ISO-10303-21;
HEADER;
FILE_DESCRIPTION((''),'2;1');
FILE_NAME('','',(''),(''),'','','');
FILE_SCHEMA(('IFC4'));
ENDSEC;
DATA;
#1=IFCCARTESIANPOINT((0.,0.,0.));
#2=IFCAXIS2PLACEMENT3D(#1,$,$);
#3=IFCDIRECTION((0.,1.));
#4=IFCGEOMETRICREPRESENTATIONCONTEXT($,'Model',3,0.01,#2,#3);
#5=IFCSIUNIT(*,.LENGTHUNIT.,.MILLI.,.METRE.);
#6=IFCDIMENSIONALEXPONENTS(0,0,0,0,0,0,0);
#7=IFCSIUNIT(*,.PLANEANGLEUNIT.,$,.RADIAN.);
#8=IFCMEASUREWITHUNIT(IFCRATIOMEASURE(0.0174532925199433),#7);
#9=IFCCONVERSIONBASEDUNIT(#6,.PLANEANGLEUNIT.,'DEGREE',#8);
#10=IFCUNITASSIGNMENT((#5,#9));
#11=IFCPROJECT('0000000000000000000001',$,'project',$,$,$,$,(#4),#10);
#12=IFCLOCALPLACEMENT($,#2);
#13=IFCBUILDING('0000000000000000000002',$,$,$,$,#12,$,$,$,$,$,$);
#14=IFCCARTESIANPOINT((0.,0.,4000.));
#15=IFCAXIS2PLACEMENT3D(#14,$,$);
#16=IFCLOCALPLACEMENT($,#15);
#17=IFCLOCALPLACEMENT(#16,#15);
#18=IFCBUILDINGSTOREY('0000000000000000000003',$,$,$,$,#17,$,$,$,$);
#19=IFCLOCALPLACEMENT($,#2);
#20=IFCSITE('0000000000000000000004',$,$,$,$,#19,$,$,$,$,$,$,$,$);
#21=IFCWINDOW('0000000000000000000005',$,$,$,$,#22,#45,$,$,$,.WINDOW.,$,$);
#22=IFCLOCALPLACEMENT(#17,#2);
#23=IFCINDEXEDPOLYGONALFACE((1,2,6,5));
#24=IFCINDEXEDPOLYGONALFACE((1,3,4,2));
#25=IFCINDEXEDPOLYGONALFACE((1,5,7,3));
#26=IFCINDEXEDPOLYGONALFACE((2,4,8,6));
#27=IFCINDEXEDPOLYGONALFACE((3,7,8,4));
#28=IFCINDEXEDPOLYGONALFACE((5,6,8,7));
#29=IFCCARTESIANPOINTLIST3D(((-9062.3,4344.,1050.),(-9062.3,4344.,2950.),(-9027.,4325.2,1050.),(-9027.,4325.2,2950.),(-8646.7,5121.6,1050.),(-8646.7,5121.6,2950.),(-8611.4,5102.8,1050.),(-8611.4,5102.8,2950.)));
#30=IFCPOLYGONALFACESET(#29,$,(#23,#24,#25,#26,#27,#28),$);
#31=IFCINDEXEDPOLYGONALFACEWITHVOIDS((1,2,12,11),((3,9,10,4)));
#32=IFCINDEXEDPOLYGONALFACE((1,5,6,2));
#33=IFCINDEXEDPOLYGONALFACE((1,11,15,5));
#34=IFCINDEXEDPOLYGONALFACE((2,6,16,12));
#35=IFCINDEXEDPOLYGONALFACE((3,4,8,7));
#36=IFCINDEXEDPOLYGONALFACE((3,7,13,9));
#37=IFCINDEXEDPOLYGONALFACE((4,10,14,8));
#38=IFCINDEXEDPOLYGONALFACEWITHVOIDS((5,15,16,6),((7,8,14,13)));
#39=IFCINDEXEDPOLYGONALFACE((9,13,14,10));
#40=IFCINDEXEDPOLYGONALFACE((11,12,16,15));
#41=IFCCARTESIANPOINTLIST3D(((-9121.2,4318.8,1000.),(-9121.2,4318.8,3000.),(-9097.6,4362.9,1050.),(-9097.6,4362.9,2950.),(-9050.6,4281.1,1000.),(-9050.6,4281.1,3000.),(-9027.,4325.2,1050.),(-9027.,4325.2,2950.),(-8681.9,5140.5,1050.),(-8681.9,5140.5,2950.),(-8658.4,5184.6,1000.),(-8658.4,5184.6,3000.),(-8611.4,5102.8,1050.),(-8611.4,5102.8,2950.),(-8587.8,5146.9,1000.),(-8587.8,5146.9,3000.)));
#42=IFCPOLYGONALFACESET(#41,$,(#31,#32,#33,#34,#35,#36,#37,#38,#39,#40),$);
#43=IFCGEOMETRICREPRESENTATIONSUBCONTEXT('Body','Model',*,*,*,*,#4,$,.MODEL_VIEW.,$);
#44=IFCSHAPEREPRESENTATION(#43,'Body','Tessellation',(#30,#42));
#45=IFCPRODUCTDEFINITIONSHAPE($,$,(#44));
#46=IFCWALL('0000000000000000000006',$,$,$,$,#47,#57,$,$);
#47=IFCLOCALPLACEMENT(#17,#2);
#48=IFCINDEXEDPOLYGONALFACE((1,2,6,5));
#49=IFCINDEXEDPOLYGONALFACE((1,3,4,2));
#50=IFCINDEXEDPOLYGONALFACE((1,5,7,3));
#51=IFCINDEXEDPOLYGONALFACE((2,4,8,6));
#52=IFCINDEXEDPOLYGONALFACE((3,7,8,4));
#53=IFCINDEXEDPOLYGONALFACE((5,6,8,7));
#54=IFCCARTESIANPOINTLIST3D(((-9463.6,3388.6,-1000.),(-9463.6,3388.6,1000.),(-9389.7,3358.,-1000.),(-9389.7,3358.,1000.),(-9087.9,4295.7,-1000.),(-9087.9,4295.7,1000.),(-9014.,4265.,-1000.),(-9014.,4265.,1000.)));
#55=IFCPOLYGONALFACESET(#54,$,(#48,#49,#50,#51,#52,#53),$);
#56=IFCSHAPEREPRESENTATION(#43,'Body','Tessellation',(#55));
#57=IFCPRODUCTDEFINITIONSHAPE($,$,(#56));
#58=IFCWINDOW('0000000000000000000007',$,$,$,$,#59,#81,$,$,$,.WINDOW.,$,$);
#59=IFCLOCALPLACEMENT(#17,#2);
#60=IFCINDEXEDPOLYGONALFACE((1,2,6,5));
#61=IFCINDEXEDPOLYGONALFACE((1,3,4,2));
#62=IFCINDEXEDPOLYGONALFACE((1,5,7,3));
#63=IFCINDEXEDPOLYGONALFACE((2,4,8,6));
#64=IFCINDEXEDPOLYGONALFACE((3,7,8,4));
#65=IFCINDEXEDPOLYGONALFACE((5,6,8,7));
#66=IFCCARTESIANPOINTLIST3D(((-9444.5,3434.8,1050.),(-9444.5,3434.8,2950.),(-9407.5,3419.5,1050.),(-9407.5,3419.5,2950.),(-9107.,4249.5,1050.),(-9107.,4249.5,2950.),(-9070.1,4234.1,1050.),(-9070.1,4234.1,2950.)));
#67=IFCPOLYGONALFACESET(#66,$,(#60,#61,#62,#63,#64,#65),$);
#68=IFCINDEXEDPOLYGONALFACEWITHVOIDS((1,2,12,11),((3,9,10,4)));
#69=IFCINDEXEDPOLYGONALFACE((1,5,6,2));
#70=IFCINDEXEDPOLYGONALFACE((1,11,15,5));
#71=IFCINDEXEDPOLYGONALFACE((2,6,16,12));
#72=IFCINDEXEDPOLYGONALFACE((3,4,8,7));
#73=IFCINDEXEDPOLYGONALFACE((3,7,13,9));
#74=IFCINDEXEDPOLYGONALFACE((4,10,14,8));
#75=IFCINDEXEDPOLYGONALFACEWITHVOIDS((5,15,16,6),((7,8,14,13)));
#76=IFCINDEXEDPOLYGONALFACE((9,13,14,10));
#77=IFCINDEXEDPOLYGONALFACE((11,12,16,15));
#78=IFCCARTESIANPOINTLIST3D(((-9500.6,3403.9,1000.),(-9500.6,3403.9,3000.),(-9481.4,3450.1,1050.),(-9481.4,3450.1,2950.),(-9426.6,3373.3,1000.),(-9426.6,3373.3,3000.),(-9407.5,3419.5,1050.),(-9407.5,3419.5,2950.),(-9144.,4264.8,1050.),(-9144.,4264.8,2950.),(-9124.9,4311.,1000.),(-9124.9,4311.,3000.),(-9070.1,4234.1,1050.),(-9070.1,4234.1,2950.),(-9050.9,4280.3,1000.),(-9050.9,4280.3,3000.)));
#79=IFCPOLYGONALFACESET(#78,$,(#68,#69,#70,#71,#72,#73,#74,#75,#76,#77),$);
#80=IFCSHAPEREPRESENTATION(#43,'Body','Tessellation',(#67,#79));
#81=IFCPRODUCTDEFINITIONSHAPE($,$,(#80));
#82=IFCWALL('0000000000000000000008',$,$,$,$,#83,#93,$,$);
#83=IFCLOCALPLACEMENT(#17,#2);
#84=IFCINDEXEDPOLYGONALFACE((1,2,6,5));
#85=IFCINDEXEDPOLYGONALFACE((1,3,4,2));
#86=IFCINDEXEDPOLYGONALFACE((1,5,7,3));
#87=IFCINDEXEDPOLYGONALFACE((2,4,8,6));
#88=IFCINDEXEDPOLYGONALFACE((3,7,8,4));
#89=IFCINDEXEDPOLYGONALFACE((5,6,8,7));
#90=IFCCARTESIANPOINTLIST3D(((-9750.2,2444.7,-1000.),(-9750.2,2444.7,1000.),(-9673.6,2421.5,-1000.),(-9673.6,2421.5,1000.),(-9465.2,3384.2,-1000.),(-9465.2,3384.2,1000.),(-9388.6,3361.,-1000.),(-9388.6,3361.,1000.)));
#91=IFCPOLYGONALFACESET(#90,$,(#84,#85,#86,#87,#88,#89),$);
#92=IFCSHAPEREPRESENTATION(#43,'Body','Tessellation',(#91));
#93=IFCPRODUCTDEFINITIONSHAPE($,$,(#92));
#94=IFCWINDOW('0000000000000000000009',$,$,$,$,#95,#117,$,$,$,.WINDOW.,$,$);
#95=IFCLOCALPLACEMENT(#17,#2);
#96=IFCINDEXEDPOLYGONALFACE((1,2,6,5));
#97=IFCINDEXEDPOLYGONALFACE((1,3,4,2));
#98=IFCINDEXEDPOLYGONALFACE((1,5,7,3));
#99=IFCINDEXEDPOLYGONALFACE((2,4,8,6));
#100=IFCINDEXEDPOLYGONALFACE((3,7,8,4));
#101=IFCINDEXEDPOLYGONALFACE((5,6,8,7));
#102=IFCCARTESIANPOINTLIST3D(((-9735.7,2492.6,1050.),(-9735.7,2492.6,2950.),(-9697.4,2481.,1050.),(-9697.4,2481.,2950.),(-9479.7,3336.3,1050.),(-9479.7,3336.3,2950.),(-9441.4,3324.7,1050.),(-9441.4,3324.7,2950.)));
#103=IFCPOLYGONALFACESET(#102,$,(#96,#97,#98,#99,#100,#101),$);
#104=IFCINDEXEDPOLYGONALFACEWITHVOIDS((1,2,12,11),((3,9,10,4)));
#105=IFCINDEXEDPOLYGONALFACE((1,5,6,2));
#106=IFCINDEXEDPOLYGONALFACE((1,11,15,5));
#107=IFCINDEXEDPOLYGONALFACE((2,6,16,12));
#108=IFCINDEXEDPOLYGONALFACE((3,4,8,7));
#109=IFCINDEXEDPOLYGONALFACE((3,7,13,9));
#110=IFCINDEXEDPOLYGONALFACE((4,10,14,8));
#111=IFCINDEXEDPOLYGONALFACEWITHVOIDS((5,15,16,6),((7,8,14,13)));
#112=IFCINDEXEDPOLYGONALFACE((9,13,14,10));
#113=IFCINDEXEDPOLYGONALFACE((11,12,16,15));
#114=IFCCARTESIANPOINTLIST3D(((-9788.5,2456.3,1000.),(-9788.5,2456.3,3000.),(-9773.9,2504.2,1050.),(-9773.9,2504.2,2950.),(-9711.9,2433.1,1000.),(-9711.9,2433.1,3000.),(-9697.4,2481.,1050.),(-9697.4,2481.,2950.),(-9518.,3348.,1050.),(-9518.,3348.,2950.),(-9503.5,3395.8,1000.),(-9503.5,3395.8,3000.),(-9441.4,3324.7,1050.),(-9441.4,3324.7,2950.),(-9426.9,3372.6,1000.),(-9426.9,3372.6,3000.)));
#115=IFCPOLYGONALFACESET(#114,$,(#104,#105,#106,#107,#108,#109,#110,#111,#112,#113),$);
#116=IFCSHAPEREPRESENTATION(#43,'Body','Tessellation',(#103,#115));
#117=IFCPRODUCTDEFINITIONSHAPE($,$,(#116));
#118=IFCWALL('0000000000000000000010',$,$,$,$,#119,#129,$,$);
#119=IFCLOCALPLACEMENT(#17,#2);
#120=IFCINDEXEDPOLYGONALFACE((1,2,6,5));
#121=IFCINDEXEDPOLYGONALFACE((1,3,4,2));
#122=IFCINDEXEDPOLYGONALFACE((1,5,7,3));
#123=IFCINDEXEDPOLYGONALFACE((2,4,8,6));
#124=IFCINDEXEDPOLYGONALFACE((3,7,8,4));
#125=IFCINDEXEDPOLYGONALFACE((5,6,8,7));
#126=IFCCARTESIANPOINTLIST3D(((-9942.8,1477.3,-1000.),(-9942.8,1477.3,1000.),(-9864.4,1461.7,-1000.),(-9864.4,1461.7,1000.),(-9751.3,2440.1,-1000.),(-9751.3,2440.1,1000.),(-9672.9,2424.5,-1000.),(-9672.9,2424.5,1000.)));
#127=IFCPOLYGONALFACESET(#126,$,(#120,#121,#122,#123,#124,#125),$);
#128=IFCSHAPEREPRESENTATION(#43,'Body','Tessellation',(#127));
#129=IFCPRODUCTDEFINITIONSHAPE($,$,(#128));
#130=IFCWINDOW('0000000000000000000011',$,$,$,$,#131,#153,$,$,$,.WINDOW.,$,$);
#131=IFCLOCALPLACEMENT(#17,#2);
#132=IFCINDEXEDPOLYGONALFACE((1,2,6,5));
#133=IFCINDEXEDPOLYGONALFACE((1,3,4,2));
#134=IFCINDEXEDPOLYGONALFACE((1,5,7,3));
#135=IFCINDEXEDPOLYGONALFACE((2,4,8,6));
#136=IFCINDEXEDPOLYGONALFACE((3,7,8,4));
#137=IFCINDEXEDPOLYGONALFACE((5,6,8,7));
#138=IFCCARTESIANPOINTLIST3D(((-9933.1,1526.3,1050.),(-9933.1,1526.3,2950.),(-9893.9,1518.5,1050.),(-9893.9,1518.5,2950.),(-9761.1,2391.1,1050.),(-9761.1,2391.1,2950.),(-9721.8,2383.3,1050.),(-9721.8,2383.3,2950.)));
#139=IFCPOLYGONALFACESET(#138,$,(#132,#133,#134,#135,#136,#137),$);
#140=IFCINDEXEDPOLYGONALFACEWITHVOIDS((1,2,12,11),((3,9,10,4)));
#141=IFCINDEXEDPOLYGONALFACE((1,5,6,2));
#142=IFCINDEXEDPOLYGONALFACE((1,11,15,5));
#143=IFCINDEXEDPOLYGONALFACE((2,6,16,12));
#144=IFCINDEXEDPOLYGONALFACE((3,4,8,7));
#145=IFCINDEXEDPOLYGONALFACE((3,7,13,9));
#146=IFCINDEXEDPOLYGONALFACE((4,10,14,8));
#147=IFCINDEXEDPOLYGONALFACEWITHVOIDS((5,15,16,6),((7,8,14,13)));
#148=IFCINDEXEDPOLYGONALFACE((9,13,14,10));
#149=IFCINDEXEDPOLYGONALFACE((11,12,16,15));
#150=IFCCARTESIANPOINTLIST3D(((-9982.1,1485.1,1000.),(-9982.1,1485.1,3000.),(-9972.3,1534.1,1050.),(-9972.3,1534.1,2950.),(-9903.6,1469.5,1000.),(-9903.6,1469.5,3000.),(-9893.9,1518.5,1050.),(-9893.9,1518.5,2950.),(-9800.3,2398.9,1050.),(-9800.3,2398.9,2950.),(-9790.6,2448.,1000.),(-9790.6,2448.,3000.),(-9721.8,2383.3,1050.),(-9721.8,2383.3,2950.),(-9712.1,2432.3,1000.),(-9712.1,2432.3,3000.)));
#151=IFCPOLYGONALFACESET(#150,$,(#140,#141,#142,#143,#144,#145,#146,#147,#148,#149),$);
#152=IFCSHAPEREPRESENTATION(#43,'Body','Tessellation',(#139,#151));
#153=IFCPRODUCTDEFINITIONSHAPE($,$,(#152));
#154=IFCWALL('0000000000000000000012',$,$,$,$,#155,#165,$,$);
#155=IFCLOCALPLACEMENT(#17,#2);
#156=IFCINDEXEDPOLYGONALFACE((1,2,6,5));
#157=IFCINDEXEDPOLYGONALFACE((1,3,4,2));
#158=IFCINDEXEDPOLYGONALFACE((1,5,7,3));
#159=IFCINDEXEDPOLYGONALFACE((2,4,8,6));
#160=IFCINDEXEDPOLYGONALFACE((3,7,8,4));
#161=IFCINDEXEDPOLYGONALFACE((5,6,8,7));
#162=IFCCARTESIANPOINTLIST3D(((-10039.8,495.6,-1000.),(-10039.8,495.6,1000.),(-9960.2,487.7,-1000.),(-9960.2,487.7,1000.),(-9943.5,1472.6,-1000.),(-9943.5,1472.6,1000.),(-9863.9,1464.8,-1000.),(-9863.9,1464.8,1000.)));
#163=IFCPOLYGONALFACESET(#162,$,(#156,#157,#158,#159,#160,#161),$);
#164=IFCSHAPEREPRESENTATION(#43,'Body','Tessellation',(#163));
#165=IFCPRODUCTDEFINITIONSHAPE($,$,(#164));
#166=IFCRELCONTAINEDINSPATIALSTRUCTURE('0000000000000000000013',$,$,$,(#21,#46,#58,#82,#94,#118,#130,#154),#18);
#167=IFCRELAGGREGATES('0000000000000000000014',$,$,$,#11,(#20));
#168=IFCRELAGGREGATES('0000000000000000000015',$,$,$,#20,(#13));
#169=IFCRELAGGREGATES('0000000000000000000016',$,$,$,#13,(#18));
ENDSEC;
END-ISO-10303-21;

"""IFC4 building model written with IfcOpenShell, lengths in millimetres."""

from ifc_helpers import new_model, entity, si_unit, converted_unit, direction, frame, origin, origin_2d, place, context, subcontext, project, spatial, rectangle, extrude, element, save


model = new_model("IFC4")

# Units and contexts
model_context = context("Model", 3, precision=0.01, world=origin(), true_north=direction((0.0, 1.0)))
body_context = subcontext(model_context, "Body", "Model", "MODEL_VIEW")
ifc_project = project(units=[si_unit("LENGTHUNIT", "METRE", prefix="MILLI"), converted_unit("PLANEANGLEUNIT", "DEGREE", entity("IfcRatioMeasure", 0.0174532925199433), si_unit("PLANEANGLEUNIT", "RADIAN"), dimensions=[0, 0, 0, 0, 0, 0, 0])], contexts=[model_context])

# Site, building, storey
site_placement = place(None, origin())
site = spatial("IfcSite", under=ifc_project, at=site_placement)
building_placement = place(None, origin())
building = spatial("IfcBuilding", under=site, at=building_placement)
placement = place(None, frame((0.0, 0.0, 4000.0)))
storey_placement = place(placement, frame((0.0, 0.0, 4000.0)))
storey = spatial("IfcBuildingStorey", under=building, at=storey_placement)

# Shared definitions
cartesian_point_1 = entity("IfcCartesianPoint", [-440.9, -950.0])
shared_polyline = entity("IfcPolyline", [cartesian_point_1, entity("IfcCartesianPoint", [-440.9, 950.0]), entity("IfcCartesianPoint", [-440.9, 950.0]), entity("IfcCartesianPoint", [440.9, 950.0]), entity("IfcCartesianPoint", [440.9, 950.0]), entity("IfcCartesianPoint", [440.9, -950.0]), entity("IfcCartesianPoint", [440.9, -950.0]), entity("IfcCartesianPoint", [-440.9, -950.0]), cartesian_point_1])

# Window
window_1_placement = place(storey_placement, frame((-8819.2, 4714.0, 2000.0), z_axis=(0.0, 0.0, 1.0), x_axis=(-4713.96836, -8819.212113, 0.0)))
cartesian_point_2 = entity("IfcCartesianPoint", [-490.9, -1000.0])
element("IfcWindow", 1, at=window_1_placement, inside=storey, PredefinedType="WINDOW", context=body_context, shape_type="SweptSolid", body=[
    entity("IfcExtrudedAreaSolid", entity("IfcArbitraryClosedProfileDef", "AREA", None, shared_polyline), entity("IfcAxis2Placement3D", entity("IfcCartesianPoint", [0.0, 0.0, 0.0]), entity("IfcDirection", [0.0, -1.0, 0.0]), entity("IfcDirection", [1.0, 0.0, 0.0])), entity("IfcDirection", [0.0, 0.0, 1.0]), 40.0),
    entity("IfcExtrudedAreaSolid", entity("IfcArbitraryProfileDefWithVoids", "AREA", None, entity("IfcPolyline", [cartesian_point_2, entity("IfcCartesianPoint", [-490.9, 1000.0]), entity("IfcCartesianPoint", [-490.9, 1000.0]), entity("IfcCartesianPoint", [490.9, 1000.0]), entity("IfcCartesianPoint", [490.9, 1000.0]), entity("IfcCartesianPoint", [490.9, -1000.0]), entity("IfcCartesianPoint", [490.9, -1000.0]), entity("IfcCartesianPoint", [-490.9, -1000.0]), cartesian_point_2]), [shared_polyline]), entity("IfcAxis2Placement3D", entity("IfcCartesianPoint", [0.0, 0.0, 0.0]), entity("IfcDirection", [0.0, -1.0, 0.0]), entity("IfcDirection", [1.0, 0.0, 0.0])), entity("IfcDirection", [0.0, 0.0, 1.0]), 80.0),
])

# Wall
wall_1_placement = place(storey_placement, frame((-9238.8, 3826.8, -1000.0), z_axis=(0.0, 0.0, 1.0), x_axis=(-3826.834994, -9238.795048, 0.0)))
element("IfcWall", 2, at=wall_1_placement, inside=storey, context=body_context, shape_type="SweptSolid", body=[
    extrude(rectangle(XDim=981.7, YDim=80.0, at=origin_2d()), origin(), (0.0, 0.0, 1.0), 2000.0),
])

# Window
window_2_placement = place(storey_placement, frame((-9238.8, 3826.8, 2000.0), z_axis=(0.0, 0.0, 1.0), x_axis=(-3826.834994, -9238.795048, 0.0)))
cartesian_point_3 = entity("IfcCartesianPoint", [-490.9, -1000.0])
element("IfcWindow", 3, at=window_2_placement, inside=storey, PredefinedType="WINDOW", context=body_context, shape_type="SweptSolid", body=[
    entity("IfcExtrudedAreaSolid", entity("IfcArbitraryClosedProfileDef", "AREA", None, shared_polyline), entity("IfcAxis2Placement3D", entity("IfcCartesianPoint", [0.0, 0.0, 0.0]), entity("IfcDirection", [0.0, -1.0, 0.0]), entity("IfcDirection", [1.0, 0.0, 0.0])), entity("IfcDirection", [0.0, 0.0, 1.0]), 40.0),
    entity("IfcExtrudedAreaSolid", entity("IfcArbitraryProfileDefWithVoids", "AREA", None, entity("IfcPolyline", [cartesian_point_3, entity("IfcCartesianPoint", [-490.9, 1000.0]), entity("IfcCartesianPoint", [-490.9, 1000.0]), entity("IfcCartesianPoint", [490.9, 1000.0]), entity("IfcCartesianPoint", [490.9, 1000.0]), entity("IfcCartesianPoint", [490.9, -1000.0]), entity("IfcCartesianPoint", [490.9, -1000.0]), entity("IfcCartesianPoint", [-490.9, -1000.0]), cartesian_point_3]), [shared_polyline]), entity("IfcAxis2Placement3D", entity("IfcCartesianPoint", [0.0, 0.0, 0.0]), entity("IfcDirection", [0.0, -1.0, 0.0]), entity("IfcDirection", [1.0, 0.0, 0.0])), entity("IfcDirection", [0.0, 0.0, 1.0]), 80.0),
])

# Wall
wall_2_placement = place(storey_placement, frame((-9569.4, 2902.8, -1000.0), z_axis=(0.0, 0.0, 1.0), x_axis=(-2902.847084, -9569.403263, 0.0)))
element("IfcWall", 4, at=wall_2_placement, inside=storey, context=body_context, shape_type="SweptSolid", body=[
    extrude(rectangle(XDim=981.7, YDim=80.0, at=origin_2d()), origin(), (0.0, 0.0, 1.0), 2000.0),
])

# Window
window_3_placement = place(storey_placement, frame((-9569.4, 2902.8, 2000.0), z_axis=(0.0, 0.0, 1.0), x_axis=(-2902.847084, -9569.403263, 0.0)))
cartesian_point_4 = entity("IfcCartesianPoint", [-490.9, -1000.0])
element("IfcWindow", 5, at=window_3_placement, inside=storey, PredefinedType="WINDOW", context=body_context, shape_type="SweptSolid", body=[
    entity("IfcExtrudedAreaSolid", entity("IfcArbitraryClosedProfileDef", "AREA", None, shared_polyline), entity("IfcAxis2Placement3D", entity("IfcCartesianPoint", [0.0, 0.0, 0.0]), entity("IfcDirection", [0.0, -1.0, 0.0]), entity("IfcDirection", [1.0, 0.0, 0.0])), entity("IfcDirection", [0.0, 0.0, 1.0]), 40.0),
    entity("IfcExtrudedAreaSolid", entity("IfcArbitraryProfileDefWithVoids", "AREA", None, entity("IfcPolyline", [cartesian_point_4, entity("IfcCartesianPoint", [-490.9, 1000.0]), entity("IfcCartesianPoint", [-490.9, 1000.0]), entity("IfcCartesianPoint", [490.9, 1000.0]), entity("IfcCartesianPoint", [490.9, 1000.0]), entity("IfcCartesianPoint", [490.9, -1000.0]), entity("IfcCartesianPoint", [490.9, -1000.0]), entity("IfcCartesianPoint", [-490.9, -1000.0]), cartesian_point_4]), [shared_polyline]), entity("IfcAxis2Placement3D", entity("IfcCartesianPoint", [0.0, 0.0, 0.0]), entity("IfcDirection", [0.0, -1.0, 0.0]), entity("IfcDirection", [1.0, 0.0, 0.0])), entity("IfcDirection", [0.0, 0.0, 1.0]), 80.0),
])

# Wall
wall_3_placement = place(storey_placement, frame((-9807.9, 1950.9, -1000.0), z_axis=(0.0, 0.0, 1.0), x_axis=(-1950.903147, -9807.852819, 0.0)))
element("IfcWall", 6, at=wall_3_placement, inside=storey, context=body_context, shape_type="SweptSolid", body=[
    extrude(rectangle(XDim=981.7, YDim=80.0, at=origin_2d()), origin(), (0.0, 0.0, 1.0), 2000.0),
])

# Window
window_4_placement = place(storey_placement, frame((-9807.9, 1950.9, 2000.0), z_axis=(0.0, 0.0, 1.0), x_axis=(-1950.903147, -9807.852819, 0.0)))
cartesian_point_5 = entity("IfcCartesianPoint", [-490.9, -1000.0])
element("IfcWindow", 7, at=window_4_placement, inside=storey, PredefinedType="WINDOW", context=body_context, shape_type="SweptSolid", body=[
    entity("IfcExtrudedAreaSolid", entity("IfcArbitraryClosedProfileDef", "AREA", None, shared_polyline), entity("IfcAxis2Placement3D", entity("IfcCartesianPoint", [0.0, 0.0, 0.0]), entity("IfcDirection", [0.0, -1.0, 0.0]), entity("IfcDirection", [1.0, 0.0, 0.0])), entity("IfcDirection", [0.0, 0.0, 1.0]), 40.0),
    entity("IfcExtrudedAreaSolid", entity("IfcArbitraryProfileDefWithVoids", "AREA", None, entity("IfcPolyline", [cartesian_point_5, entity("IfcCartesianPoint", [-490.9, 1000.0]), entity("IfcCartesianPoint", [-490.9, 1000.0]), entity("IfcCartesianPoint", [490.9, 1000.0]), entity("IfcCartesianPoint", [490.9, 1000.0]), entity("IfcCartesianPoint", [490.9, -1000.0]), entity("IfcCartesianPoint", [490.9, -1000.0]), entity("IfcCartesianPoint", [-490.9, -1000.0]), cartesian_point_5]), [shared_polyline]), entity("IfcAxis2Placement3D", entity("IfcCartesianPoint", [0.0, 0.0, 0.0]), entity("IfcDirection", [0.0, -1.0, 0.0]), entity("IfcDirection", [1.0, 0.0, 0.0])), entity("IfcDirection", [0.0, 0.0, 1.0]), 80.0),
])

# Wall
wall_4_placement = place(storey_placement, frame((-9951.8, 980.2, -1000.0), z_axis=(0.0, 0.0, 1.0), x_axis=(-980.170931, -9951.847313, 0.0)))
element("IfcWall", 8, at=wall_4_placement, inside=storey, context=body_context, shape_type="SweptSolid", body=[
    extrude(rectangle(XDim=981.7, YDim=80.0, at=origin_2d()), origin(), (0.0, 0.0, 1.0), 2000.0),
])

save(model, "model.ifc")
